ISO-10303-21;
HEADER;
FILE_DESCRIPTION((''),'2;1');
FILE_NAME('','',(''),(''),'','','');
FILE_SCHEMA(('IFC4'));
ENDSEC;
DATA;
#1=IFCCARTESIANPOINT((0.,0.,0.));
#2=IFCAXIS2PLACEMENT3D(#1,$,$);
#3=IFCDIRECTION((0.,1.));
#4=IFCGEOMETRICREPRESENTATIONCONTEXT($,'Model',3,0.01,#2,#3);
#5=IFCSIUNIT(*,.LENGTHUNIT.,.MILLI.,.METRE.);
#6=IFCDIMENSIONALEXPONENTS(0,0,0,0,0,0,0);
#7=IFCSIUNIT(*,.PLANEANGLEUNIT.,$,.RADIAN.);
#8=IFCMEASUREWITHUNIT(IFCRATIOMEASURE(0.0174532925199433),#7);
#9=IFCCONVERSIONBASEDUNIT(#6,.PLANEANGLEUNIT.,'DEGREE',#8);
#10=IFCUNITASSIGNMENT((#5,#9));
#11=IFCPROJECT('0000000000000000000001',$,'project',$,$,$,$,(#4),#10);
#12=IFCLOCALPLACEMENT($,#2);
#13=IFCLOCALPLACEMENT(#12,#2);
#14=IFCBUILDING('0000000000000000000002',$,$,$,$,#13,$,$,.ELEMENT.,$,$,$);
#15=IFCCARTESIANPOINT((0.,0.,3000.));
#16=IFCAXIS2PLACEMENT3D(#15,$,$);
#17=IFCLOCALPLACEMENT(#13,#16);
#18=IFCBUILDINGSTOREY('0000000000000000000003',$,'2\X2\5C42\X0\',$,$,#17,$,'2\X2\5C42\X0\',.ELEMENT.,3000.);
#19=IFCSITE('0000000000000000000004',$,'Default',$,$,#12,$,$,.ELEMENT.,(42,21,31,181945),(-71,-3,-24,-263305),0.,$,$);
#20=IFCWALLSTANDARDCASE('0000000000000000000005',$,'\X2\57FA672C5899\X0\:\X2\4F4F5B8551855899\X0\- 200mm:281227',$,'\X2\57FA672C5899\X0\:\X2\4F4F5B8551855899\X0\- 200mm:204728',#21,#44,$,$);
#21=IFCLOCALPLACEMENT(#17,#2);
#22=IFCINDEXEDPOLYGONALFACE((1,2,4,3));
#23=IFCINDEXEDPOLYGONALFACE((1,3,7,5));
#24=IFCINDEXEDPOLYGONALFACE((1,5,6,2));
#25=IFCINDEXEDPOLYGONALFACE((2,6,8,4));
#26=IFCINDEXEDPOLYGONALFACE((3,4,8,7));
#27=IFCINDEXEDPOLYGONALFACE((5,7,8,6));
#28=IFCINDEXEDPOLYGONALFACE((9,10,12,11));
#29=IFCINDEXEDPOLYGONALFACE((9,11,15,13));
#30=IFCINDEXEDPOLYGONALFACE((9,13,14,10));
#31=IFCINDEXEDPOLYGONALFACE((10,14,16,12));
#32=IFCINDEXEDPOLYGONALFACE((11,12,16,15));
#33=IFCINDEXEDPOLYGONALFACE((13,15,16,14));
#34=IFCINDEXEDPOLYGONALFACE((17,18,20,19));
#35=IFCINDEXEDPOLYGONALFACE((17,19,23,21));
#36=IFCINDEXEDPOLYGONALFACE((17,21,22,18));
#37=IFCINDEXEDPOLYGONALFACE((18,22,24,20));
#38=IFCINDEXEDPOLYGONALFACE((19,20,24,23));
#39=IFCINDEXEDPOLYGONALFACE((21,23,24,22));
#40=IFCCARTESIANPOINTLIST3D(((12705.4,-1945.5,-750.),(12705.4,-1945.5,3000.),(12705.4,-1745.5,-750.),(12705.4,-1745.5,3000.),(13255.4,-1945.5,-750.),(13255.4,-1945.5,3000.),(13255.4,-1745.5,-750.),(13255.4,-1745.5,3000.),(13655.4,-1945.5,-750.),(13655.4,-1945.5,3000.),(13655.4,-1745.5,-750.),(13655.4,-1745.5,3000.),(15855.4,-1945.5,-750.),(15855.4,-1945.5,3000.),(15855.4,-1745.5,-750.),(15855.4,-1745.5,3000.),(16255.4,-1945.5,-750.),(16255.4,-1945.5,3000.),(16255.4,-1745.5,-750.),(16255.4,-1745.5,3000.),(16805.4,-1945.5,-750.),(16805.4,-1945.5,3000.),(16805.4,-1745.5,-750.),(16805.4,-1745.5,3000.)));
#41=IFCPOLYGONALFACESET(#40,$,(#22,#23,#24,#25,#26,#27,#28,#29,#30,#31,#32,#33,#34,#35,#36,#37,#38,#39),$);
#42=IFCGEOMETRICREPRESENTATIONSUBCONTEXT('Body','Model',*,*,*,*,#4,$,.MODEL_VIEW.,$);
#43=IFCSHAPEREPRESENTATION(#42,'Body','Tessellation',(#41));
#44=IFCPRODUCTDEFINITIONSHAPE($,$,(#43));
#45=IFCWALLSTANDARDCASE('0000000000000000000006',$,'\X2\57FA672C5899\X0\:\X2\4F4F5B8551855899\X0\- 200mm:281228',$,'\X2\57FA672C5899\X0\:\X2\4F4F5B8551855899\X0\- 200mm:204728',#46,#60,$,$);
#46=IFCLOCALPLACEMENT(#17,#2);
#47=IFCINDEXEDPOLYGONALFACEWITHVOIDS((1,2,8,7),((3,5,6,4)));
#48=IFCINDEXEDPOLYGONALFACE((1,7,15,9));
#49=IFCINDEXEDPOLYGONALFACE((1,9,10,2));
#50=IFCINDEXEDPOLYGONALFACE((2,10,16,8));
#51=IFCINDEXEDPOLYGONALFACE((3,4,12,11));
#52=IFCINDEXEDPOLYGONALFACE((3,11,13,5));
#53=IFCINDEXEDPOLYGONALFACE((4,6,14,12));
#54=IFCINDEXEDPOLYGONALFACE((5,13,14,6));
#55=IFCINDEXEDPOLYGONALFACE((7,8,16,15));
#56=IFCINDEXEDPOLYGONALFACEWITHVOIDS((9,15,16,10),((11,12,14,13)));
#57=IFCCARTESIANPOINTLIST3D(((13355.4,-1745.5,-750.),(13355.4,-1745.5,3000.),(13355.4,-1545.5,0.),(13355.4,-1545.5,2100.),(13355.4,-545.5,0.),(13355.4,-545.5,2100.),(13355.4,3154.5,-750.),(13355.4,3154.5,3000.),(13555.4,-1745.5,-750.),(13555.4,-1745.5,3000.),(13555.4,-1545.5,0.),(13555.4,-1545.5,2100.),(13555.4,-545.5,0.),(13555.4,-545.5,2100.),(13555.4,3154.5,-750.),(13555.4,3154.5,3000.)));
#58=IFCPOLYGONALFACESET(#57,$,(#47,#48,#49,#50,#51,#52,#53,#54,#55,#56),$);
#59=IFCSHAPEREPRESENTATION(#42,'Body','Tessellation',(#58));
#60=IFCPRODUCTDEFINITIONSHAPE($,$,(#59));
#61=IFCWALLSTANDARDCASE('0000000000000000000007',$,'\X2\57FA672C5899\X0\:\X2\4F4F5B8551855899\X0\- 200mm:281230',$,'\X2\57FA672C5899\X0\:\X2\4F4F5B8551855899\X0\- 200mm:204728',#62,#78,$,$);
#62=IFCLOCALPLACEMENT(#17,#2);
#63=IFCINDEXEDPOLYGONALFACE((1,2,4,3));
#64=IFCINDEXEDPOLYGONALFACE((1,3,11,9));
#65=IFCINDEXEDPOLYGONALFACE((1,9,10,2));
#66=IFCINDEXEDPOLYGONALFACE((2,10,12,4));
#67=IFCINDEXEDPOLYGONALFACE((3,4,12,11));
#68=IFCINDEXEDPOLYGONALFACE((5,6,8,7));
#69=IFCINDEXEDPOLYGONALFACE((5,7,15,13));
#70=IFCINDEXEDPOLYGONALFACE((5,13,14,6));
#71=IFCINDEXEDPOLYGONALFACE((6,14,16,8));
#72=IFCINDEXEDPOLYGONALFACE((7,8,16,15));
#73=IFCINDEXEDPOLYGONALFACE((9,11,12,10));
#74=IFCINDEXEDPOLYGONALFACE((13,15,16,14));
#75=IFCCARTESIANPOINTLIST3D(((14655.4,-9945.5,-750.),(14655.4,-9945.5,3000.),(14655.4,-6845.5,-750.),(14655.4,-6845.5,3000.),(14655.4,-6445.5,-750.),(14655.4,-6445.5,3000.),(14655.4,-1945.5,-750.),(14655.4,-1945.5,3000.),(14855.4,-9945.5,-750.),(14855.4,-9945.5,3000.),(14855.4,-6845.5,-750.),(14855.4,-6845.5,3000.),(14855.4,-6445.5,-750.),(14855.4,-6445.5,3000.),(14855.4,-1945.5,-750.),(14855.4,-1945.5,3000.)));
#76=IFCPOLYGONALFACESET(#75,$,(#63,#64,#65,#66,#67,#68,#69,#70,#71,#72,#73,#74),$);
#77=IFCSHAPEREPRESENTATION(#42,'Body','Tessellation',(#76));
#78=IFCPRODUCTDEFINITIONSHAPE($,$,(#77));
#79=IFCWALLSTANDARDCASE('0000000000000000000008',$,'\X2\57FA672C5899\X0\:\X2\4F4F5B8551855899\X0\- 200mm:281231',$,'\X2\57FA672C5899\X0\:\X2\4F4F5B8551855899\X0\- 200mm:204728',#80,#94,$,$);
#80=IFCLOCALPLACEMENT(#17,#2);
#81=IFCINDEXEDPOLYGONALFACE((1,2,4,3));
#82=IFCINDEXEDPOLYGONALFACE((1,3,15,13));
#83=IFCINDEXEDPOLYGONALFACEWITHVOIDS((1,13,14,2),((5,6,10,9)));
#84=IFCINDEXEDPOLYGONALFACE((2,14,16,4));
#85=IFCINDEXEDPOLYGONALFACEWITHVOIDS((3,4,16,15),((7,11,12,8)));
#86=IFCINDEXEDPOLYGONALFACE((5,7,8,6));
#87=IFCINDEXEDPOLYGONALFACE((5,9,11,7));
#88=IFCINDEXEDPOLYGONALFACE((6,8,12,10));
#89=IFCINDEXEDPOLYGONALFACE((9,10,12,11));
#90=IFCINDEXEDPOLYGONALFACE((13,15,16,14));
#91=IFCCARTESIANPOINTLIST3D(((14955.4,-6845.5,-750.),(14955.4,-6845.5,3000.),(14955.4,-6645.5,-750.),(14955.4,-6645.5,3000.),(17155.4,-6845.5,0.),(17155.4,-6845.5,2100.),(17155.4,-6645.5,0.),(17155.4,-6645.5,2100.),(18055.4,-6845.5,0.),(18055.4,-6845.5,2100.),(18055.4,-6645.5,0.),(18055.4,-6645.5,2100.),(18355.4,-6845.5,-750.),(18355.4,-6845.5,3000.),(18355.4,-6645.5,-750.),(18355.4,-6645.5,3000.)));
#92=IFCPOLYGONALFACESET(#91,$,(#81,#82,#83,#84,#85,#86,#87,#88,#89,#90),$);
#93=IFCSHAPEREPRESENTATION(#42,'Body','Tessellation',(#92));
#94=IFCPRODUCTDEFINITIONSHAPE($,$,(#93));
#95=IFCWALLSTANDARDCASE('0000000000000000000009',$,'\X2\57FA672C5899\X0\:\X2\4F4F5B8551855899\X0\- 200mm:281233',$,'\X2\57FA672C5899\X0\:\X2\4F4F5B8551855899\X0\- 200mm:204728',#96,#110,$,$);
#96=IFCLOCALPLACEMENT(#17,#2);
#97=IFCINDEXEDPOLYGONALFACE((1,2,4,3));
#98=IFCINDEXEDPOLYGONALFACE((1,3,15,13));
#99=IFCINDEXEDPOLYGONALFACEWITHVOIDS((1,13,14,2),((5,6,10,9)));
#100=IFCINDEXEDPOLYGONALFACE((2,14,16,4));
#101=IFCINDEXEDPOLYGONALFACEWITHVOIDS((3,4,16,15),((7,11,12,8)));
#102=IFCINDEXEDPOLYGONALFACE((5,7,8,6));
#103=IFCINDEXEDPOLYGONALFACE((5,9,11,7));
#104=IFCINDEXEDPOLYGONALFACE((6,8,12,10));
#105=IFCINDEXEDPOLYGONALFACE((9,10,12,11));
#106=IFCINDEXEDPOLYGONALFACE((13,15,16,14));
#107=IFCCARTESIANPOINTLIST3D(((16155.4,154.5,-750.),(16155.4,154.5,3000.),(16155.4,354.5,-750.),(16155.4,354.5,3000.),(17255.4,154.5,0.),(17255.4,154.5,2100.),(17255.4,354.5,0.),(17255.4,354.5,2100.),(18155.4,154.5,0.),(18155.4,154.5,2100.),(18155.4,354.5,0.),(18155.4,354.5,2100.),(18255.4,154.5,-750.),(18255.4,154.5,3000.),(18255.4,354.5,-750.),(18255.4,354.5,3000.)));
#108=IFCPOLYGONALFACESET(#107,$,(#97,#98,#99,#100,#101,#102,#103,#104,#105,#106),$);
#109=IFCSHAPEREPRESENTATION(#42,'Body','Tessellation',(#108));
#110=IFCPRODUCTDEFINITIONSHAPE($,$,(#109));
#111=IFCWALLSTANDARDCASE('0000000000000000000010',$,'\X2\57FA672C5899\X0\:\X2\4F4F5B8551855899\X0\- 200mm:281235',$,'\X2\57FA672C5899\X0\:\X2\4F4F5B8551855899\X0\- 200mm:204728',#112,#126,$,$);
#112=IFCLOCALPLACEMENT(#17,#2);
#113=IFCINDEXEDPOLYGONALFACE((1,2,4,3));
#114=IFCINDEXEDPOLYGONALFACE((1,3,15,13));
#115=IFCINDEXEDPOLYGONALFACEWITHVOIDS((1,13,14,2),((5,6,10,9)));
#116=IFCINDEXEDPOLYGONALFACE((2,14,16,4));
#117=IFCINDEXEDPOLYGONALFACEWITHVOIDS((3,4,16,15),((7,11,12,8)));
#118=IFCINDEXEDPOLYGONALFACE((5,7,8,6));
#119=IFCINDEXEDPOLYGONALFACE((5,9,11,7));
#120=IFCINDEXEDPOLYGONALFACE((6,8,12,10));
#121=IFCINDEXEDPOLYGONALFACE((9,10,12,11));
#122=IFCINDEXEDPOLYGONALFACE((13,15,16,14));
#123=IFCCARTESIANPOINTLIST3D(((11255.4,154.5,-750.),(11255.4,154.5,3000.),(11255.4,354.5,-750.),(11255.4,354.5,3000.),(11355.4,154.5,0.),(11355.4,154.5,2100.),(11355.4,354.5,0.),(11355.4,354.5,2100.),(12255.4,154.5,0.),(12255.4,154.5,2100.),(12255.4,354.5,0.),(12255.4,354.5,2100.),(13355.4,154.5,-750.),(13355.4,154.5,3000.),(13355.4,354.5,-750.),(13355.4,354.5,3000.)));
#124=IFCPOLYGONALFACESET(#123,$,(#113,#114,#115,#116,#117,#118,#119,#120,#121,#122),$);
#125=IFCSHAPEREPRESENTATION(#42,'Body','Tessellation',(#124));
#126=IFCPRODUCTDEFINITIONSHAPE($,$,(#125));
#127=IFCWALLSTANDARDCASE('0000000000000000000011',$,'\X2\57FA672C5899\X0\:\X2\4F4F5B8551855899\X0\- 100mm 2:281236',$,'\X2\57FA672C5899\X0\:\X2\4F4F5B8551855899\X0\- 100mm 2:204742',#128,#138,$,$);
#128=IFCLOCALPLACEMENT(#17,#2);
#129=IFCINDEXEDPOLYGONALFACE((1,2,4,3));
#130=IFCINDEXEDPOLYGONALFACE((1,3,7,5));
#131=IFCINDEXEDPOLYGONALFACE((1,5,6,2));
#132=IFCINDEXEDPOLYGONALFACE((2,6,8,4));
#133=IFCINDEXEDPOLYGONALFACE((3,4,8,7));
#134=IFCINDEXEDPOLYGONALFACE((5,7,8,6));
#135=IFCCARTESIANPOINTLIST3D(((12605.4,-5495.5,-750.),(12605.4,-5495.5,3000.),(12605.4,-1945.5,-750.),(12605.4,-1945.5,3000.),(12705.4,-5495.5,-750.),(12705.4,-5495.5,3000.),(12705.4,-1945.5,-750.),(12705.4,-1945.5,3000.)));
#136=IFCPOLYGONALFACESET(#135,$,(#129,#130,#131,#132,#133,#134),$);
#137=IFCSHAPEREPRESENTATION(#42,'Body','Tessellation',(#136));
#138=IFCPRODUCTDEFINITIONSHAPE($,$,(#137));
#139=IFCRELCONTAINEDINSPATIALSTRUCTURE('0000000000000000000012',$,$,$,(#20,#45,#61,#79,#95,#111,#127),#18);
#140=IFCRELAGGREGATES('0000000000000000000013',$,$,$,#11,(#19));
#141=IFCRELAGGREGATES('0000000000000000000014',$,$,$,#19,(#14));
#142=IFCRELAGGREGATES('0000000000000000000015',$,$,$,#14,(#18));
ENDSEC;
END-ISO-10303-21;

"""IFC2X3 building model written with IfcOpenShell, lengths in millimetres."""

from ifc_helpers import new_model, entity, si_unit, converted_unit, direction, frame, frame_2d, origin, place, context, subcontext, project, spatial, polyline, rectangle, extrude, clip, bounded_halfspace, element, save


model = new_model("IFC2X3")

# Units and contexts
model_context = context("Model", 3, precision=0.01, world=origin(), true_north=direction((0.0, 1.0)))
body_context = subcontext(model_context, "Body", "Model", "MODEL_VIEW")
ifc_project = project(units=[si_unit("LENGTHUNIT", "METRE", prefix="MILLI"), converted_unit("PLANEANGLEUNIT", "DEGREE", entity("IfcRatioMeasure", 0.0174532925199433), si_unit("PLANEANGLEUNIT", "RADIAN"), dimensions=[0, 0, 0, 0, 0, 0, 0])], contexts=[model_context])

# Site, building, storey
site_placement = place(None, origin())
site = spatial("IfcSite", under=ifc_project, at=site_placement, Name="Default", CompositionType="ELEMENT", RefLatitude=(42, 21, 31, 181945), RefLongitude=(-71, -3, -24, -263305), RefElevation=0.0)
building_placement = place(site_placement, origin())
building = spatial("IfcBuilding", under=site, at=building_placement, CompositionType="ELEMENT")
storey_placement = place(building_placement, frame((0.0, 0.0, 3000.0)))
storey = spatial("IfcBuildingStorey", under=building, at=storey_placement, Name="2层", LongName="2层", CompositionType="ELEMENT", Elevation=3000.0)

# Wall, openings
wall_1_placement = place(storey_placement, frame((16805.4, -1845.5, -750.0), z_axis=(0.0, 0.0, 1.0), x_axis=(-1.0, 0.0, 0.0)))
wall_1 = element("IfcWallStandardCase", 1, at=wall_1_placement, inside=storey, Name="基本墙:住宅内墙- 200mm:281227", ObjectType="基本墙:住宅内墙- 200mm:204728", context=body_context, shape_type="SweptSolid", body=[
    extrude(rectangle(XDim=4100.0, YDim=200.0, at=frame_2d((2050.0, 0.0), x_axis=(-1.0, 0.0))), origin(), (0.0, 0.0, 1.0), 3750.0),
])
opening_1_placement = place(storey_placement, frame((16805.4, -1845.5, -750.0), z_axis=(0.0, 0.0, 1.0), x_axis=(-1.0, 0.0, 0.0)))
element("IfcOpeningElement", 2, at=opening_1_placement, cuts=wall_1, ObjectType="Opening", context=body_context, shape_type="SweptSolid", body=[
    extrude(rectangle(XDim=3750.0, YDim=200.0, at=frame_2d((0.0, 0.0), x_axis=(1.0, 0.0))), frame((3550.0, 0.0, 1875.0), z_axis=(-1.0, 0.0, 0.0), x_axis=(0.0, 0.0, 1.0)), (0.0, 0.0, 1.0), 400.0),
])
opening_2_placement = place(storey_placement, frame((16805.4, -1845.5, -750.0), z_axis=(0.0, 0.0, 1.0), x_axis=(-1.0, 0.0, 0.0)))
element("IfcOpeningElement", 3, at=opening_2_placement, cuts=wall_1, ObjectType="Opening", context=body_context, shape_type="SweptSolid", body=[
    extrude(rectangle(XDim=3750.0, YDim=200.0, at=frame_2d((0.0, 0.0), x_axis=(1.0, 0.0))), frame((950.0, 0.0, 1875.0), z_axis=(-1.0, 0.0, 0.0), x_axis=(0.0, 0.0, 1.0)), (0.0, 0.0, 1.0), 400.0),
])

# Walls, openings
wall_2_placement = place(storey_placement, frame((13455.4, -1745.5, -750.0), z_axis=(0.0, 0.0, 1.0), x_axis=(0.0, 1.0, 0.0)))
wall_2 = element("IfcWallStandardCase", 4, at=wall_2_placement, inside=storey, Name="基本墙:住宅内墙- 200mm:281228", ObjectType="基本墙:住宅内墙- 200mm:204728", context=body_context, shape_type="SweptSolid", body=[
    extrude(rectangle(XDim=4900.0, YDim=200.0, at=frame_2d((2450.0, 0.0), x_axis=(-1.0, 0.0))), origin(), (0.0, 0.0, 1.0), 3750.0),
])
opening_3_placement = place(wall_2_placement, frame((1200.0, 100.0, 750.0)))
element("IfcOpeningElement", 5, at=opening_3_placement, cuts=wall_2, ObjectType="Opening", context=body_context, shape_type="SweptSolid", body=[
    extrude(rectangle(XDim=2100.0, YDim=1000.0, at=frame_2d((1050.0, 500.0), x_axis=(1.0, 0.0))), frame((0.0, 0.0, 0.0), z_axis=(0.0, -1.0, 0.0), x_axis=(0.0, 0.0, 1.0)), (0.0, 0.0, 1.0), 200.0),
])
wall_3_placement = place(storey_placement, frame((14755.4, -1945.5, -750.0), z_axis=(0.0, 0.0, 1.0), x_axis=(0.0, -1.0, 0.0)))
wall_3 = element("IfcWallStandardCase", 6, at=wall_3_placement, inside=storey, Name="基本墙:住宅内墙- 200mm:281230", ObjectType="基本墙:住宅内墙- 200mm:204728", context=body_context, shape_type="Clipping", body=[
    clip(extrude(rectangle(XDim=8000.0, YDim=200.0, at=frame_2d((4000.0, 0.0), x_axis=(-1.0, 0.0))), origin(), (0.0, 0.0, 1.0), 3750.0), bounded_halfspace(frame((8000.0, -100.0, 3750.0), z_axis=(1.0, 0.0, 0.0), x_axis=(0.0, 0.0, -1.0)), False, frame((8000.0, -100.0, 3750.0), z_axis=(1.0, 0.0, 0.0), x_axis=(0.0, 0.0, -1.0)), polyline([(0.0, 0.0), (3750.0, 0.0), (3750.0, 200.0), (0.0, 200.0), (0.0, 0.0)]))),
])
opening_4_placement = place(storey_placement, frame((14755.4, -1945.5, -750.0), z_axis=(0.0, 0.0, 1.0), x_axis=(0.0, -1.0, 0.0)))
element("IfcOpeningElement", 7, at=opening_4_placement, cuts=wall_3, ObjectType="Opening", context=body_context, shape_type="SweptSolid", body=[
    extrude(rectangle(XDim=3750.0, YDim=200.0, at=frame_2d((0.0, 0.0), x_axis=(1.0, 0.0))), frame((4900.0, 0.0, 1875.0), z_axis=(-1.0, 0.0, 0.0), x_axis=(0.0, 0.0, 1.0)), (0.0, 0.0, 1.0), 400.0),
])

# Wall, openings
wall_4_placement = place(storey_placement, frame((18355.4, -6745.5, -750.0), z_axis=(0.0, 0.0, 1.0), x_axis=(-1.0, 0.0, 0.0)))
wall_4 = element("IfcWallStandardCase", 8, at=wall_4_placement, inside=storey, Name="基本墙:住宅内墙- 200mm:281231", ObjectType="基本墙:住宅内墙- 200mm:204728", context=body_context, shape_type="Clipping", body=[
    clip(extrude(rectangle(XDim=3400.0, YDim=200.0, at=frame_2d((1700.0, 0.0), x_axis=(-1.0, 0.0))), origin(), (0.0, 0.0, 1.0), 3750.0), bounded_halfspace(frame((3400.0, -100.0, 3750.0), z_axis=(1.0, 0.0, 0.0), x_axis=(0.0, 0.0, -1.0)), False, frame((3400.0, -100.0, 3750.0), z_axis=(1.0, 0.0, 0.0), x_axis=(0.0, 0.0, -1.0)), polyline([(0.0, 0.0), (3750.0, 0.0), (3750.0, 200.0), (0.0, 200.0), (0.0, 0.0)]))),
])
opening_5_placement = place(wall_4_placement, origin())
element("IfcOpeningElement", 9, at=opening_5_placement, cuts=wall_4, ObjectType="Opening", context=body_context, shape_type="SweptSolid", body=[
    extrude(rectangle(XDim=2100.0, YDim=900.0, at=frame_2d((0.0, 0.0), x_axis=(1.0, 0.0))), frame((750.0, -1624.0, 4800.0), z_axis=(0.0, 1.0, 0.0), x_axis=(0.0, 0.0, 1.0)), (0.0, 0.0, 1.0), 3048.0),
])
opening_6_placement = place(wall_4_placement, origin())
element("IfcOpeningElement", 10, at=opening_6_placement, cuts=wall_4, ObjectType="Opening", context=body_context, shape_type="SweptSolid", body=[
    extrude(rectangle(XDim=2100.0, YDim=900.0, at=frame_2d((0.0, 0.0), x_axis=(1.0, 0.0))), frame((750.0, -1624.0, 1800.0), z_axis=(0.0, 1.0, 0.0), x_axis=(0.0, 0.0, 1.0)), (0.0, 0.0, 1.0), 3048.0),
])

# Wall, opening
wall_5_placement = place(storey_placement, frame((18255.4, 254.5, -750.0), z_axis=(0.0, 0.0, 1.0), x_axis=(-1.0, 0.0, 0.0)))
wall_5 = element("IfcWallStandardCase", 11, at=wall_5_placement, inside=storey, Name="基本墙:住宅内墙- 200mm:281233", ObjectType="基本墙:住宅内墙- 200mm:204728", context=body_context, shape_type="SweptSolid", body=[
    extrude(rectangle(XDim=2100.0, YDim=200.0, at=frame_2d((1050.0, 0.0), x_axis=(-1.0, 0.0))), origin(), (0.0, 0.0, 1.0), 3750.0),
])
opening_7_placement = place(wall_5_placement, frame((1000.0, 100.0, 750.0)))
element("IfcOpeningElement", 12, at=opening_7_placement, cuts=wall_5, ObjectType="Opening", context=body_context, shape_type="SweptSolid", body=[
    extrude(rectangle(XDim=2100.0, YDim=900.0, at=frame_2d((1050.0, 450.0), x_axis=(1.0, 0.0))), frame((0.0, 0.0, 0.0), z_axis=(0.0, -1.0, 0.0), x_axis=(0.0, 0.0, 1.0)), (0.0, 0.0, 1.0), 200.0),
])

# Wall, opening
wall_6_placement = place(storey_placement, frame((11255.4, 254.5, -750.0)))
wall_6 = element("IfcWallStandardCase", 13, at=wall_6_placement, inside=storey, Name="基本墙:住宅内墙- 200mm:281235", ObjectType="基本墙:住宅内墙- 200mm:204728", context=body_context, shape_type="SweptSolid", body=[
    extrude(rectangle(XDim=2100.0, YDim=200.0, at=frame_2d((1050.0, 0.0), x_axis=(-1.0, 0.0))), origin(), (0.0, 0.0, 1.0), 3750.0),
])
opening_8_placement = place(wall_6_placement, frame((100.0, -100.0, 750.0)))
element("IfcOpeningElement", 14, at=opening_8_placement, cuts=wall_6, ObjectType="Opening", context=body_context, shape_type="SweptSolid", body=[
    extrude(rectangle(XDim=2100.0, YDim=900.0, at=frame_2d((1050.0, 450.0), x_axis=(1.0, 0.0))), frame((0.0, 0.0, 0.0), z_axis=(0.0, 1.0, 0.0), x_axis=(0.0, 0.0, 1.0)), (0.0, 0.0, 1.0), 200.0),
])

# Wall
wall_7_placement = place(storey_placement, frame((12655.4, -1945.5, -750.0), z_axis=(0.0, 0.0, 1.0), x_axis=(0.0, -1.0, 0.0)))
element("IfcWallStandardCase", 15, at=wall_7_placement, inside=storey, Name="基本墙:住宅内墙- 100mm 2:281236", ObjectType="基本墙:住宅内墙- 100mm 2:204742", context=body_context, shape_type="SweptSolid", body=[
    extrude(rectangle(XDim=3550.0, YDim=100.0, at=frame_2d((1775.0, 0.0), x_axis=(-1.0, 0.0))), origin(), (0.0, 0.0, 1.0), 3750.0),
])

save(model, "model.ifc")
